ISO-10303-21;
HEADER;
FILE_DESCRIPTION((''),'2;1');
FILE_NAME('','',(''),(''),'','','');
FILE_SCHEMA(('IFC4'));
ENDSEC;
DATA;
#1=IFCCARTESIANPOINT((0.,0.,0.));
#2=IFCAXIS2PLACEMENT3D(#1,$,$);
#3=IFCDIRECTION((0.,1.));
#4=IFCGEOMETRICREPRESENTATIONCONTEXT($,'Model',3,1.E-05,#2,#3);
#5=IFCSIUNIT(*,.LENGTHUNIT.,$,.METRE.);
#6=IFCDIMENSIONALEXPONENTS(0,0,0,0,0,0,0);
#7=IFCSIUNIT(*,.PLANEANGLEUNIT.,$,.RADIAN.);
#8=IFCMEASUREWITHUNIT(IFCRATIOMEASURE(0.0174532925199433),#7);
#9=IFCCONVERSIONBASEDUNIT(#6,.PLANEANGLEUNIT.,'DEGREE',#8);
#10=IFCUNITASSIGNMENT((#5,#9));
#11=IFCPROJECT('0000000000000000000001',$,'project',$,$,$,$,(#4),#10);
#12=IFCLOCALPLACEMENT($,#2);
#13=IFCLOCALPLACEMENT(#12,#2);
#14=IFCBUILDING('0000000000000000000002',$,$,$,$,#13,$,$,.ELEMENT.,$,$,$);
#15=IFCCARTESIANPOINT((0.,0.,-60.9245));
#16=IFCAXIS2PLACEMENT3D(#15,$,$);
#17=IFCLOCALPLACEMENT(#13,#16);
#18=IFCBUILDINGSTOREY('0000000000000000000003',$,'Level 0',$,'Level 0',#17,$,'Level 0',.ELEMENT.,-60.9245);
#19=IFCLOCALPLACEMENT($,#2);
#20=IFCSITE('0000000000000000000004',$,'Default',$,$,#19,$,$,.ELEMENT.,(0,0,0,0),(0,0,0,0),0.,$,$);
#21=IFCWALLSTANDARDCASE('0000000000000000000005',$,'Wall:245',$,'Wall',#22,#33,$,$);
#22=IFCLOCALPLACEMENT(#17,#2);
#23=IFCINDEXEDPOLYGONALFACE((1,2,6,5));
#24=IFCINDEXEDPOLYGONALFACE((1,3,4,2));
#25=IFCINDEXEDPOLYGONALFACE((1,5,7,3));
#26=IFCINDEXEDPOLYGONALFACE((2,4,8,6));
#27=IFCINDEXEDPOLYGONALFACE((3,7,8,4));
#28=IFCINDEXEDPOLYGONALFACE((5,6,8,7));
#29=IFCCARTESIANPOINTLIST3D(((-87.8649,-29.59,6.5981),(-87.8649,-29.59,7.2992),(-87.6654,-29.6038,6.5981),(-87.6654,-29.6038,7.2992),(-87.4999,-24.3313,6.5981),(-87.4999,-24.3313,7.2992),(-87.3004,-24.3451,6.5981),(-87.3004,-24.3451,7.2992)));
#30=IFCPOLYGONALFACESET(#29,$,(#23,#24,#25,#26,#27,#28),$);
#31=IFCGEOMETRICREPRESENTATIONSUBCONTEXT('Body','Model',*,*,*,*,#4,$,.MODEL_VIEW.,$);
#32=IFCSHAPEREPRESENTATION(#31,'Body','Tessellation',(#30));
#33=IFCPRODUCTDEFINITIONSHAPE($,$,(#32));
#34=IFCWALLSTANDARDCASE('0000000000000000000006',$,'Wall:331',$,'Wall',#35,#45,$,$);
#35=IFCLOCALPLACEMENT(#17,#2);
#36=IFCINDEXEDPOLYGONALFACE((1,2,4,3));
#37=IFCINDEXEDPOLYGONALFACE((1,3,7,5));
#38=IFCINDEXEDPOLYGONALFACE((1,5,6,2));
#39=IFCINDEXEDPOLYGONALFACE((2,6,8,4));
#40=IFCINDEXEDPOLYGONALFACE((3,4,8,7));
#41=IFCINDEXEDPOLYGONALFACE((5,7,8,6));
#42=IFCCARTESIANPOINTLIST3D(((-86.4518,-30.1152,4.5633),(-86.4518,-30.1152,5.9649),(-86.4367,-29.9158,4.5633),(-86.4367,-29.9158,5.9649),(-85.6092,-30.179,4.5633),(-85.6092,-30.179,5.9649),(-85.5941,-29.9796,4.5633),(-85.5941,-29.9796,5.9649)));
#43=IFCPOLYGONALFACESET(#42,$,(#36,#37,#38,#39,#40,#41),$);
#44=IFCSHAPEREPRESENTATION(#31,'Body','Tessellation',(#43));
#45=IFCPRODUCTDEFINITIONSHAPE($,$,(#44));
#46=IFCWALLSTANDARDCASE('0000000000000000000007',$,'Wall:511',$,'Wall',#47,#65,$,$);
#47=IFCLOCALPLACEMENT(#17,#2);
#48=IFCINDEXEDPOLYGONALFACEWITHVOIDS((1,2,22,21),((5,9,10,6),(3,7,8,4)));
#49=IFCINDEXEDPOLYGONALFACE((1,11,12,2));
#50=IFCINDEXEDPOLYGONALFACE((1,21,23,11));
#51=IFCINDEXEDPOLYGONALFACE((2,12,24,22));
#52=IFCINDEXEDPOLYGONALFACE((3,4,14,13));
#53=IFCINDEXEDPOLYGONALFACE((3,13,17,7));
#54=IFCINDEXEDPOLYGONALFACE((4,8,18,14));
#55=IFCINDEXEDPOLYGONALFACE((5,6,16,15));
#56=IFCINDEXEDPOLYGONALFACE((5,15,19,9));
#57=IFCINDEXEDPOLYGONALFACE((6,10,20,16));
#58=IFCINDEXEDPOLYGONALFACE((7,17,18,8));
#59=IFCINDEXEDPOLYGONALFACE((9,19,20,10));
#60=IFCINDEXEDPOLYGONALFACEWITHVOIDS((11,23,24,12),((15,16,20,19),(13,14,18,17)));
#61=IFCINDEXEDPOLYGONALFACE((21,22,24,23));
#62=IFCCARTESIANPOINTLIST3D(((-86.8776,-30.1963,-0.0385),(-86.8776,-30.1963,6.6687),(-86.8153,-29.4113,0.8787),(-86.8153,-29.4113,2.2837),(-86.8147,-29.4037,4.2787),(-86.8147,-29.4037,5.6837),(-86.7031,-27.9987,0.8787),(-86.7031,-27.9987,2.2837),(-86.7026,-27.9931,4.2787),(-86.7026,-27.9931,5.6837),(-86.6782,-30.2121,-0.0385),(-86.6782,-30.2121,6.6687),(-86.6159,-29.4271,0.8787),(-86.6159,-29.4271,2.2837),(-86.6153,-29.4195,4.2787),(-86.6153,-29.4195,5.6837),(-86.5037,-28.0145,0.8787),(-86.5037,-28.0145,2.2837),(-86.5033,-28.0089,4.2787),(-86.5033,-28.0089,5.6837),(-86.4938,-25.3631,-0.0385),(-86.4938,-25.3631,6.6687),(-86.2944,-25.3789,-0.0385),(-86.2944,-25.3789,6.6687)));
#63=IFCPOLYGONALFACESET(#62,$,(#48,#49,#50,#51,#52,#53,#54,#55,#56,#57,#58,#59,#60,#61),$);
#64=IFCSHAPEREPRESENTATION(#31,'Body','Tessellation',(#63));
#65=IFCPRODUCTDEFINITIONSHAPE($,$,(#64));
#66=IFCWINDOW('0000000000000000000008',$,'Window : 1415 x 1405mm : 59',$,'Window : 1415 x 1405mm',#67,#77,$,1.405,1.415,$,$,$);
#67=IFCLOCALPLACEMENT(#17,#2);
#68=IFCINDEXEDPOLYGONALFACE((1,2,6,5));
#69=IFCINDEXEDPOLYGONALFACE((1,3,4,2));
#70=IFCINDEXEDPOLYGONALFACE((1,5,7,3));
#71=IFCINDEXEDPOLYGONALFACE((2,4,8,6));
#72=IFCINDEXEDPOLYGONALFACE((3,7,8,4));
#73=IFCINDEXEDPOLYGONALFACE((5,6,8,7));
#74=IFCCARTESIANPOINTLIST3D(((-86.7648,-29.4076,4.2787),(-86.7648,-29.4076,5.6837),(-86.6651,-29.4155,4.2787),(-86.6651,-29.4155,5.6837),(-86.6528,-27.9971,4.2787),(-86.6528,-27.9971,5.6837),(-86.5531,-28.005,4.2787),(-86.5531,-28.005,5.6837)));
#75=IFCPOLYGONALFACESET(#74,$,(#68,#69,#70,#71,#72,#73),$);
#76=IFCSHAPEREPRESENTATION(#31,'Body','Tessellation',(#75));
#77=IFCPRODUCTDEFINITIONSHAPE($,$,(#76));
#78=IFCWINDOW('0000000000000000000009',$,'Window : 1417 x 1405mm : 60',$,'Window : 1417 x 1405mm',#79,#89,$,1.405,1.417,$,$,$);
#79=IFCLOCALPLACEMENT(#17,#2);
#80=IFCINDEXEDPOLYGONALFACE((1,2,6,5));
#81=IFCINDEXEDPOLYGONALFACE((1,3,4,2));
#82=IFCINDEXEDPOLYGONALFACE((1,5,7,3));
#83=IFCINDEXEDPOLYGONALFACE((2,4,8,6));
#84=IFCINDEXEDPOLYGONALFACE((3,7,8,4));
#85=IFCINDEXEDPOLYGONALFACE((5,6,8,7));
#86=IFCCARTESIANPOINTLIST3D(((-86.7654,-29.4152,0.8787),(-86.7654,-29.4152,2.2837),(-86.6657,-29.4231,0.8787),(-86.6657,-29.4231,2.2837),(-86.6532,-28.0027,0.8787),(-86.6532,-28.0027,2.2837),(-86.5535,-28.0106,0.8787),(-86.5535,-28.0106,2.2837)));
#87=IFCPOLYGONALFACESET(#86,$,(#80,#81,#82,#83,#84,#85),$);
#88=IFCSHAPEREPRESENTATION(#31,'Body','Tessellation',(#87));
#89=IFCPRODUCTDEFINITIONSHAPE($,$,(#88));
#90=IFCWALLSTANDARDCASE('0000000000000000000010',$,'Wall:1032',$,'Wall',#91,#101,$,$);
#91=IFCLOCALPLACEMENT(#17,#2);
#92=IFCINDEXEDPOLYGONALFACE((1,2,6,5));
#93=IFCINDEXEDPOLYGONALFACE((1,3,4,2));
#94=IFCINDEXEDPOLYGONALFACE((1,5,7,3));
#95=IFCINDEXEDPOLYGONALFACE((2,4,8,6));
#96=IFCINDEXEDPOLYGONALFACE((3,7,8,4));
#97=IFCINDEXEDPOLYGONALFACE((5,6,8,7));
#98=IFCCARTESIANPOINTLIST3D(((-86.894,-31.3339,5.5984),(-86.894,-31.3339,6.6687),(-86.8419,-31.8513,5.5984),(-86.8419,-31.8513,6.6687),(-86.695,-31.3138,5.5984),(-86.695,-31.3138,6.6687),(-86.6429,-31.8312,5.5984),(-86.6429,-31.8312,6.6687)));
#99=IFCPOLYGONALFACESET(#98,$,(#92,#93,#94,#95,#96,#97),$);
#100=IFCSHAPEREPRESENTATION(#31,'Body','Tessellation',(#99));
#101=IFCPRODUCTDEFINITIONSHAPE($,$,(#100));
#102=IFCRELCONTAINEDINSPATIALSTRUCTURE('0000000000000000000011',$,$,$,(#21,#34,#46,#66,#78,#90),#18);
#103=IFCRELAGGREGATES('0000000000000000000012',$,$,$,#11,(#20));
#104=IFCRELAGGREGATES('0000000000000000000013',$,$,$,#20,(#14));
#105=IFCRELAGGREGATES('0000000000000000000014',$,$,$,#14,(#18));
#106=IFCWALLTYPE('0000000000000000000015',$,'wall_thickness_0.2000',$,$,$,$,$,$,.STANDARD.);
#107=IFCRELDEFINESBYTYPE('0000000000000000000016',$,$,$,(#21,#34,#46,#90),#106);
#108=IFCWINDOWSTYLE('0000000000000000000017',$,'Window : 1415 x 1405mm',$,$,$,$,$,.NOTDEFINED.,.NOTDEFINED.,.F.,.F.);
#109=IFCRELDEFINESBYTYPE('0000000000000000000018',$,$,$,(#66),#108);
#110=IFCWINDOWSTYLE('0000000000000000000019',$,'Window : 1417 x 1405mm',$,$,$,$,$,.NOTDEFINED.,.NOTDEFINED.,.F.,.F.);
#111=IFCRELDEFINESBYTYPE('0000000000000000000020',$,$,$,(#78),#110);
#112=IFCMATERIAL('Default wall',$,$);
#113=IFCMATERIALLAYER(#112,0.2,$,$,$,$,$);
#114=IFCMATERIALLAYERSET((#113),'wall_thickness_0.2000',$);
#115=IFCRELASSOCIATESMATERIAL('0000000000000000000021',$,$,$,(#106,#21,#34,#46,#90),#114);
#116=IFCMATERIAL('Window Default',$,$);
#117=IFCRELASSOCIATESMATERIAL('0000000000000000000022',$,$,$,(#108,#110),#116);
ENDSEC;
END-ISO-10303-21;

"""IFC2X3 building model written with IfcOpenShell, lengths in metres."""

from ifc_helpers import new_model, entity, si_unit, converted_unit, direction, frame, frame_2d, origin, origin_2d_with_axis, place, context, subcontext, project, spatial, polyline, rectangle, outline, extrude, source, transform, mapped, material, layer, layer_set, layer_usage, type_object, type_shapes, element, fill, save


model = new_model("IFC2X3")

# Units and contexts
model_context = context("Model", 3, precision=1e-05, world=origin(), true_north=direction((0.0, 1.0)))
body_context = subcontext(model_context, "Body", "Model", "MODEL_VIEW")
ifc_project = project(units=[si_unit("LENGTHUNIT", "METRE"), converted_unit("PLANEANGLEUNIT", "DEGREE", entity("IfcRatioMeasure", 0.0174532925199433), si_unit("PLANEANGLEUNIT", "RADIAN"), dimensions=[0, 0, 0, 0, 0, 0, 0])], contexts=[model_context])

# Site, building, storey
site_placement = place(None, origin())
site = spatial("IfcSite", under=ifc_project, at=site_placement, Name="Default", CompositionType="ELEMENT", RefLatitude=(0, 0, 0, 0), RefLongitude=(0, 0, 0, 0), RefElevation=0.0)
placement_1 = place(None, origin())
building_placement = place(placement_1, origin())
building = spatial("IfcBuilding", under=site, at=building_placement, CompositionType="ELEMENT")
storey_placement = place(building_placement, frame((0.0, 0.0, -60.9245)))
storey = spatial("IfcBuildingStorey", under=building, at=storey_placement, Name="Level 0", ObjectType="Level 0", LongName="Level 0", CompositionType="ELEMENT", Elevation=-60.9245)

# Walls
ifc_material_1 = material(Name="Default wall")
ifc_layer = layer(ifc_material_1, 0.2)
ifc_layer_set = layer_set([ifc_layer], Name="wall_thickness_0.2000")
ifc_layer_usage = layer_usage(ifc_layer_set, "AXIS2", "POSITIVE", -0.1)
wall_type = type_object("IfcWallType", Name="wall_thickness_0.2000", PredefinedType="STANDARD", material=ifc_layer_set)
placement_2 = place(building_placement, frame((0.0, 0.0, -54.3264)))
wall_1_placement = place(placement_2, frame((-87.7652, -29.5969, 0.0), z_axis=(0.0, 0.0, 1.0), x_axis=(0.069243, 0.9976, 0.0)))
element("IfcWallStandardCase", 1, at=wall_1_placement, inside=storey, type_object=wall_type, material=ifc_layer_usage, Name="Wall:245", ObjectType="Wall", context=body_context, shape_type="SweptSolid", body=[
    extrude(outline(polyline([(5.2713, -0.1), (5.2713, 0.1), (0.0, 0.1), (0.0, -0.1), (5.2713, -0.1)])), origin(), (0.0, 0.0, 1.0), 0.7011),
])
placement_3 = place(building_placement, frame((0.0, 0.0, -56.3612)))
wall_2_placement = place(placement_3, frame((-85.6017, -30.0793, 0.0), z_axis=(0.0, 0.0, 1.0), x_axis=(-0.997145, 0.075508, 0.0)))
element("IfcWallStandardCase", 2, at=wall_2_placement, inside=storey, type_object=wall_type, material=ifc_layer_usage, Name="Wall:331", ObjectType="Wall", context=body_context, shape_type="SweptSolid", body=[
    extrude(outline(polyline([(0.845, -0.1), (0.845, 0.1), (0.0, 0.1), (0.0, -0.1), (0.845, -0.1)])), origin(), (0.0, 0.0, 1.0), 1.4017),
])

# Wall, openings, windows
placement_4 = place(building_placement, frame((0.0, 0.0, -60.963)))
wall_3_placement = place(placement_4, frame((-86.7779, -30.2042, 0.0), z_axis=(0.0, 0.0, 1.0), x_axis=(0.07917, 0.996861, 0.0)))
wall_3 = element("IfcWallStandardCase", 3, at=wall_3_placement, inside=storey, type_object=wall_type, material=ifc_layer_usage, Name="Wall:511", ObjectType="Wall", context=body_context, shape_type="SweptSolid", body=[
    extrude(outline(polyline([(4.8485, -0.1), (4.8485, 0.1), (0.0, 0.1), (0.0, -0.1), (4.8485, -0.1)])), origin(), (0.0, 0.0, 1.0), 6.7072),
])
opening_1_placement = place(wall_3_placement, frame((0.7951, -0.1, 4.3172)))
opening_1 = element("IfcOpeningElement", 4, at=opening_1_placement, cuts=wall_3, ObjectType="Opening", context=body_context, shape_type="SweptSolid", body=[
    extrude(rectangle(XDim=1.415, YDim=1.405, at=frame_2d((0.7025, 0.7075), x_axis=(0.0, 1.0))), frame((0.0, 0.0, 0.0), z_axis=(0.0, 1.0, 0.0), x_axis=(0.0, 0.0, 1.0)), (0.0, 0.0, 1.0), 0.2),
])
opening_2_placement = place(wall_3_placement, frame((0.7875, -0.1, 0.9172)))
opening_2 = element("IfcOpeningElement", 5, at=opening_2_placement, cuts=wall_3, ObjectType="Opening", context=body_context, shape_type="SweptSolid", body=[
    extrude(rectangle(XDim=1.417, YDim=1.405, at=frame_2d((0.7025, 0.7085), x_axis=(0.0, 1.0))), frame((0.0, 0.0, 0.0), z_axis=(0.0, 1.0, 0.0), x_axis=(0.0, 0.0, 1.0)), (0.0, 0.0, 1.0), 0.2),
])
ifc_material_2 = material(Name="Window Default")
window_style_1 = type_object("IfcWindowStyle", Name="Window : 1415 x 1405mm", ConstructionType="NOTDEFINED", OperationType="NOTDEFINED", ParameterTakesPrecedence=False, Sizeable=False, material=ifc_material_2)
shared_shape_1 = source(origin(), body_context, "Body", "SweptSolid", [
    extrude(rectangle(XDim=0.1, YDim=1.415, at=origin_2d_with_axis()), frame((0.7075, 0.1, 0.0), z_axis=(0.0, 0.0, 1.0), x_axis=(0.0, 1.0, 0.0)), (0.0, 0.0, 1.0), 1.405),
])
type_shapes(window_style_1, [shared_shape_1])
window_1_placement = place(opening_1_placement, origin())
window_1 = element("IfcWindow", 6, at=window_1_placement, inside=storey, type_object=window_style_1, Name="Window : 1415 x 1405mm : 59", ObjectType="Window : 1415 x 1405mm", OverallHeight=1.405, OverallWidth=1.415, context=body_context, shape_type="MappedRepresentation", body=[
    mapped(shared_shape_1, transform((0.0, 0.0, 0.0), scale=1.0)),
])
fill(opening_1, window_1)
window_style_2 = type_object("IfcWindowStyle", Name="Window : 1417 x 1405mm", ConstructionType="NOTDEFINED", OperationType="NOTDEFINED", ParameterTakesPrecedence=False, Sizeable=False, material=ifc_material_2)
shared_shape_2 = source(origin(), body_context, "Body", "SweptSolid", [
    extrude(rectangle(XDim=0.1, YDim=1.417, at=origin_2d_with_axis()), frame((0.7085, 0.1, 0.0), z_axis=(0.0, 0.0, 1.0), x_axis=(0.0, 1.0, 0.0)), (0.0, 0.0, 1.0), 1.405),
])
type_shapes(window_style_2, [shared_shape_2])
window_2_placement = place(opening_2_placement, origin())
window_2 = element("IfcWindow", 7, at=window_2_placement, inside=storey, type_object=window_style_2, Name="Window : 1417 x 1405mm : 60", ObjectType="Window : 1417 x 1405mm", OverallHeight=1.405, OverallWidth=1.417, context=body_context, shape_type="MappedRepresentation", body=[
    mapped(shared_shape_2, transform((0.0, 0.0, 0.0), scale=1.0)),
])
fill(opening_2, window_2)

# Wall
placement_5 = place(building_placement, frame((0.0, 0.0, -55.3261)))
wall_4_placement = place(placement_5, frame((-86.7424, -31.8413, 0.0), z_axis=(0.0, 0.0, 1.0), x_axis=(-0.100283, 0.994959, 0.0)))
element("IfcWallStandardCase", 8, at=wall_4_placement, inside=storey, type_object=wall_type, material=ifc_layer_usage, Name="Wall:1032", ObjectType="Wall", context=body_context, shape_type="SweptSolid", body=[
    extrude(outline(polyline([(0.52, -0.1), (0.52, 0.1), (0.0, 0.1), (0.0, -0.1), (0.52, -0.1)])), origin(), (0.0, 0.0, 1.0), 1.0703),
])

save(model, "model.ifc")
